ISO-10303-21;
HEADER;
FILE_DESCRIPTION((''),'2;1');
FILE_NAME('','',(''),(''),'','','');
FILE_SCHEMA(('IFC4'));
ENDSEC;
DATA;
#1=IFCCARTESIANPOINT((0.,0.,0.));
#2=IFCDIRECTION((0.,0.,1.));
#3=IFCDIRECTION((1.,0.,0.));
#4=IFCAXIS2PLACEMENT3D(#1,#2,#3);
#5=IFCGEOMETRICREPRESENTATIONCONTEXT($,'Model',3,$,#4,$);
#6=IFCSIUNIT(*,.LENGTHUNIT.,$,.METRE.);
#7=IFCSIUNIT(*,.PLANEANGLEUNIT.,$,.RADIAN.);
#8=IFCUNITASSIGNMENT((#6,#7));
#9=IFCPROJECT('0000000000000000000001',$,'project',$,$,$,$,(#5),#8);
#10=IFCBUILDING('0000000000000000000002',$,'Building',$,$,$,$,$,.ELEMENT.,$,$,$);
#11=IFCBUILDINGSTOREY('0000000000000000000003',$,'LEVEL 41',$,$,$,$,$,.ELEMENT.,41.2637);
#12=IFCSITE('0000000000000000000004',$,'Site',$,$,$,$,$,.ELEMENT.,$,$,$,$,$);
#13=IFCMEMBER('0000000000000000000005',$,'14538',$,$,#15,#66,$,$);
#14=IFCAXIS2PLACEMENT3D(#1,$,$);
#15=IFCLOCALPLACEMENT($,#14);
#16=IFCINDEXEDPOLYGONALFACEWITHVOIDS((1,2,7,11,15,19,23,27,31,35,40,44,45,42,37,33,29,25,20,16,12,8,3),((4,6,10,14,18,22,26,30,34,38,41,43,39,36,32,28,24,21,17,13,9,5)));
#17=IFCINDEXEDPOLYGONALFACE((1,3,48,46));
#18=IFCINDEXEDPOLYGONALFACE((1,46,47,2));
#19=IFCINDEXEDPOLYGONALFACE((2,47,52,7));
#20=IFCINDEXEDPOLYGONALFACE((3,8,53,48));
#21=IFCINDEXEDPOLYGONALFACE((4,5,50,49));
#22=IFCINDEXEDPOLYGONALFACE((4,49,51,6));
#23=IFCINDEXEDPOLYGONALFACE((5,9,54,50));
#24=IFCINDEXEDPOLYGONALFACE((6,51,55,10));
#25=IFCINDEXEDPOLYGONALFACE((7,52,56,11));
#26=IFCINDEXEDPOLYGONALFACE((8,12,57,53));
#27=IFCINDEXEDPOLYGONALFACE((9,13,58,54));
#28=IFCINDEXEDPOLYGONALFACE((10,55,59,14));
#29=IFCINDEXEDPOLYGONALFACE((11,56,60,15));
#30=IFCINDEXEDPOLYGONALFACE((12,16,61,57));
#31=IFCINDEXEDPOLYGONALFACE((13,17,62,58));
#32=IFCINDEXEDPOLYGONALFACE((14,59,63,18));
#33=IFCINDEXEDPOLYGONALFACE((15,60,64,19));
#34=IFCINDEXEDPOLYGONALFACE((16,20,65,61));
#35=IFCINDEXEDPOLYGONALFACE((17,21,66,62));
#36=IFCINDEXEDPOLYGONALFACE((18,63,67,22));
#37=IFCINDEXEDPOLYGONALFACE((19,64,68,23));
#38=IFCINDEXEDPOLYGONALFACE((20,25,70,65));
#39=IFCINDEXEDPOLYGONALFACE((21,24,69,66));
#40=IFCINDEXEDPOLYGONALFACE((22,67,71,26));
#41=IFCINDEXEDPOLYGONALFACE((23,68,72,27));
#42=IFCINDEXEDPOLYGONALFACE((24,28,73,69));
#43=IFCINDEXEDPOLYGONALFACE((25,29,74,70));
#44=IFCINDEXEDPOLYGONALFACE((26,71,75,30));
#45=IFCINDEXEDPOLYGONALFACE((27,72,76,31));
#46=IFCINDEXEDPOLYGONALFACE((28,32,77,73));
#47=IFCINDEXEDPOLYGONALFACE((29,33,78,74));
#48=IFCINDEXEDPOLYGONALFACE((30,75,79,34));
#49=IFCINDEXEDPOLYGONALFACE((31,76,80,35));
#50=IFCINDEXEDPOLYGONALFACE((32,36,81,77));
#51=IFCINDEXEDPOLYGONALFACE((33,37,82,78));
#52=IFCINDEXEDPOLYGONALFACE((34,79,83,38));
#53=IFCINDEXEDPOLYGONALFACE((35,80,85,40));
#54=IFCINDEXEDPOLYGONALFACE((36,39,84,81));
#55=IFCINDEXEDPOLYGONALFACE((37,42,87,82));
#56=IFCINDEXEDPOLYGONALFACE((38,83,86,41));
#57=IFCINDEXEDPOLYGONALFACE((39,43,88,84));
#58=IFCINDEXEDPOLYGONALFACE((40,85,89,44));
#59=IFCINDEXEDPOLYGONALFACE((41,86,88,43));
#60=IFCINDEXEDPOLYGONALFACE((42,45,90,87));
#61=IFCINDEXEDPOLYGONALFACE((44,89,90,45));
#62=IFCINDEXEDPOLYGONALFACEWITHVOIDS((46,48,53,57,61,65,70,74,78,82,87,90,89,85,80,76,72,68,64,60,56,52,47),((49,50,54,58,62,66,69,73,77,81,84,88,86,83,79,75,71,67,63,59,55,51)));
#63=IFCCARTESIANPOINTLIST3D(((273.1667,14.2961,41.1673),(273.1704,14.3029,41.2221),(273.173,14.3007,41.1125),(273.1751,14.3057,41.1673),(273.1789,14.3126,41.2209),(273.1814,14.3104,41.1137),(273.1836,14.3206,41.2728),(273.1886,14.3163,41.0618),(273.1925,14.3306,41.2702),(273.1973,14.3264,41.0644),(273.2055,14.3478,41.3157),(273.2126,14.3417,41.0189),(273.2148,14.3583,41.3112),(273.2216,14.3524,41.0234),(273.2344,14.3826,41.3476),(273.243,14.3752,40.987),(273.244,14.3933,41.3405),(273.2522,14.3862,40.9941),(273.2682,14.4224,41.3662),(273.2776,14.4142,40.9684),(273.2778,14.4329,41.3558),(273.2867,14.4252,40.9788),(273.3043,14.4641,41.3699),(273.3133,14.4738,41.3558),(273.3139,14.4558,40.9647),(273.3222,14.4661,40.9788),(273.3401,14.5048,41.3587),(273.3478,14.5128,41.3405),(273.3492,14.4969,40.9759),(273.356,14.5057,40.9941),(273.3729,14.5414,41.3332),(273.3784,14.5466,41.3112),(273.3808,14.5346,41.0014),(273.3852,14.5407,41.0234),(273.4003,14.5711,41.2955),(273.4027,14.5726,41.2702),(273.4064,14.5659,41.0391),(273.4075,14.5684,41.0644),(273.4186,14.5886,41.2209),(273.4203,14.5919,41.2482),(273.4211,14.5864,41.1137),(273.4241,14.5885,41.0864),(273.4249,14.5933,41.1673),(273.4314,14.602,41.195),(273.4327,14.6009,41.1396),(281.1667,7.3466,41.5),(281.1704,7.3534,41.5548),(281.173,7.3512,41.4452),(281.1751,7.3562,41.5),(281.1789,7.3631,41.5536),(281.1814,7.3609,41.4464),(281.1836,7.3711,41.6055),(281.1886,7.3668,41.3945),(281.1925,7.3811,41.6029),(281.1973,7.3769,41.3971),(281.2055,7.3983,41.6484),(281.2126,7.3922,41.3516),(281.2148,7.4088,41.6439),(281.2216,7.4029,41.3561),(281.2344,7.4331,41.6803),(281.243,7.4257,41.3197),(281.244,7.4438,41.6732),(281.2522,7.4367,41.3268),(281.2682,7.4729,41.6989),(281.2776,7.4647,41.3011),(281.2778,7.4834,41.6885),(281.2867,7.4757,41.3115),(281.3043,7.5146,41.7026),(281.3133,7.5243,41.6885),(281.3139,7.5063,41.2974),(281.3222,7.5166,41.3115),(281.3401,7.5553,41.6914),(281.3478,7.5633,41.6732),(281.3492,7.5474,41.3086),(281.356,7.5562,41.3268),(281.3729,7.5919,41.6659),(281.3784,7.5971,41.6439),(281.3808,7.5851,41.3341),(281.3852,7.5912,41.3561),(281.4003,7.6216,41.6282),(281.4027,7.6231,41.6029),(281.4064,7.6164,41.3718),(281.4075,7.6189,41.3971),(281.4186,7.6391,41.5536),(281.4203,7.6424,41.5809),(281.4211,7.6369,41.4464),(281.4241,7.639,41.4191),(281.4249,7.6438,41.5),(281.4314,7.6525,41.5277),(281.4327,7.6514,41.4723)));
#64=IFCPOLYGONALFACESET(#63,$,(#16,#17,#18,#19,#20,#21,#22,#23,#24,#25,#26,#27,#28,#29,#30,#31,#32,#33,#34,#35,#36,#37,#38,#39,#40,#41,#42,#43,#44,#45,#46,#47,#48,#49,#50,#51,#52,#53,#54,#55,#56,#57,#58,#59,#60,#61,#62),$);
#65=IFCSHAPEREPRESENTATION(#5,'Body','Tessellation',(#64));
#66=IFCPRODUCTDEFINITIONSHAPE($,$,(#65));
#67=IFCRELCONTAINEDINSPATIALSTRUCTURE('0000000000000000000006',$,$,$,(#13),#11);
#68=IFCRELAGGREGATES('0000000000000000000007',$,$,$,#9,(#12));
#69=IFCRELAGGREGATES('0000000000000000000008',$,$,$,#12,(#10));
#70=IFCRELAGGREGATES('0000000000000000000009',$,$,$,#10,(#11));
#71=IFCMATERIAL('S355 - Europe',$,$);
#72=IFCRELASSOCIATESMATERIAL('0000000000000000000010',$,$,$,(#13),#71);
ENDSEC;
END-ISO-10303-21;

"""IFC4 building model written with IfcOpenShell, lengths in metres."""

from ifc_helpers import new_model, si_unit, frame, origin_with_axes, origin_2d_with_axis, place, context, project, spatial, hollow_circle, extrude, material, material_profile, profile_set, profile_usage, element, save


model = new_model("IFC4")

# Units and contexts
model_context = context("Model", 3, world=origin_with_axes())
ifc_project = project(units=[si_unit("LENGTHUNIT", "METRE"), si_unit("PLANEANGLEUNIT", "RADIAN")], contexts=[model_context])

# Site, building, storey
site = spatial("IfcSite", under=ifc_project, Name="Site", CompositionType="ELEMENT")
building = spatial("IfcBuilding", under=site, Name="Building", CompositionType="ELEMENT")
storey = spatial("IfcBuildingStorey", under=building, Name="LEVEL 41", CompositionType="ELEMENT", Elevation=41.2637)

# Shared definitions
ifc_material = material(Name="S355 - Europe")

# Member
ifc_material_profile_1 = material_profile(ifc_material, hollow_circle(Radius=0.2032, WallThickness=0.0127, at=origin_2d_with_axis()))
ifc_profile_set_1 = profile_set([ifc_material_profile_1])
ifc_profile_usage_1 = profile_usage(ifc_profile_set_1, cardinal=10)
member_1_placement = place(None, frame((281.3, 7.5, 41.5), z_axis=(-0.754562, 0.655478, -0.03138), x_axis=(-0.655227, -0.755432, 0.0)))
element("IfcMember", 1, at=member_1_placement, inside=storey, material=ifc_profile_usage_1, Name="14538", context=model_context, shape_type="SweptSolid", body=[
    extrude(hollow_circle(Radius=0.2032, WallThickness=0.0127, at=origin_2d_with_axis()), origin_with_axes(), (0.0, 0.0, 1.0), 10.6022),
])

save(model, "model.ifc")
